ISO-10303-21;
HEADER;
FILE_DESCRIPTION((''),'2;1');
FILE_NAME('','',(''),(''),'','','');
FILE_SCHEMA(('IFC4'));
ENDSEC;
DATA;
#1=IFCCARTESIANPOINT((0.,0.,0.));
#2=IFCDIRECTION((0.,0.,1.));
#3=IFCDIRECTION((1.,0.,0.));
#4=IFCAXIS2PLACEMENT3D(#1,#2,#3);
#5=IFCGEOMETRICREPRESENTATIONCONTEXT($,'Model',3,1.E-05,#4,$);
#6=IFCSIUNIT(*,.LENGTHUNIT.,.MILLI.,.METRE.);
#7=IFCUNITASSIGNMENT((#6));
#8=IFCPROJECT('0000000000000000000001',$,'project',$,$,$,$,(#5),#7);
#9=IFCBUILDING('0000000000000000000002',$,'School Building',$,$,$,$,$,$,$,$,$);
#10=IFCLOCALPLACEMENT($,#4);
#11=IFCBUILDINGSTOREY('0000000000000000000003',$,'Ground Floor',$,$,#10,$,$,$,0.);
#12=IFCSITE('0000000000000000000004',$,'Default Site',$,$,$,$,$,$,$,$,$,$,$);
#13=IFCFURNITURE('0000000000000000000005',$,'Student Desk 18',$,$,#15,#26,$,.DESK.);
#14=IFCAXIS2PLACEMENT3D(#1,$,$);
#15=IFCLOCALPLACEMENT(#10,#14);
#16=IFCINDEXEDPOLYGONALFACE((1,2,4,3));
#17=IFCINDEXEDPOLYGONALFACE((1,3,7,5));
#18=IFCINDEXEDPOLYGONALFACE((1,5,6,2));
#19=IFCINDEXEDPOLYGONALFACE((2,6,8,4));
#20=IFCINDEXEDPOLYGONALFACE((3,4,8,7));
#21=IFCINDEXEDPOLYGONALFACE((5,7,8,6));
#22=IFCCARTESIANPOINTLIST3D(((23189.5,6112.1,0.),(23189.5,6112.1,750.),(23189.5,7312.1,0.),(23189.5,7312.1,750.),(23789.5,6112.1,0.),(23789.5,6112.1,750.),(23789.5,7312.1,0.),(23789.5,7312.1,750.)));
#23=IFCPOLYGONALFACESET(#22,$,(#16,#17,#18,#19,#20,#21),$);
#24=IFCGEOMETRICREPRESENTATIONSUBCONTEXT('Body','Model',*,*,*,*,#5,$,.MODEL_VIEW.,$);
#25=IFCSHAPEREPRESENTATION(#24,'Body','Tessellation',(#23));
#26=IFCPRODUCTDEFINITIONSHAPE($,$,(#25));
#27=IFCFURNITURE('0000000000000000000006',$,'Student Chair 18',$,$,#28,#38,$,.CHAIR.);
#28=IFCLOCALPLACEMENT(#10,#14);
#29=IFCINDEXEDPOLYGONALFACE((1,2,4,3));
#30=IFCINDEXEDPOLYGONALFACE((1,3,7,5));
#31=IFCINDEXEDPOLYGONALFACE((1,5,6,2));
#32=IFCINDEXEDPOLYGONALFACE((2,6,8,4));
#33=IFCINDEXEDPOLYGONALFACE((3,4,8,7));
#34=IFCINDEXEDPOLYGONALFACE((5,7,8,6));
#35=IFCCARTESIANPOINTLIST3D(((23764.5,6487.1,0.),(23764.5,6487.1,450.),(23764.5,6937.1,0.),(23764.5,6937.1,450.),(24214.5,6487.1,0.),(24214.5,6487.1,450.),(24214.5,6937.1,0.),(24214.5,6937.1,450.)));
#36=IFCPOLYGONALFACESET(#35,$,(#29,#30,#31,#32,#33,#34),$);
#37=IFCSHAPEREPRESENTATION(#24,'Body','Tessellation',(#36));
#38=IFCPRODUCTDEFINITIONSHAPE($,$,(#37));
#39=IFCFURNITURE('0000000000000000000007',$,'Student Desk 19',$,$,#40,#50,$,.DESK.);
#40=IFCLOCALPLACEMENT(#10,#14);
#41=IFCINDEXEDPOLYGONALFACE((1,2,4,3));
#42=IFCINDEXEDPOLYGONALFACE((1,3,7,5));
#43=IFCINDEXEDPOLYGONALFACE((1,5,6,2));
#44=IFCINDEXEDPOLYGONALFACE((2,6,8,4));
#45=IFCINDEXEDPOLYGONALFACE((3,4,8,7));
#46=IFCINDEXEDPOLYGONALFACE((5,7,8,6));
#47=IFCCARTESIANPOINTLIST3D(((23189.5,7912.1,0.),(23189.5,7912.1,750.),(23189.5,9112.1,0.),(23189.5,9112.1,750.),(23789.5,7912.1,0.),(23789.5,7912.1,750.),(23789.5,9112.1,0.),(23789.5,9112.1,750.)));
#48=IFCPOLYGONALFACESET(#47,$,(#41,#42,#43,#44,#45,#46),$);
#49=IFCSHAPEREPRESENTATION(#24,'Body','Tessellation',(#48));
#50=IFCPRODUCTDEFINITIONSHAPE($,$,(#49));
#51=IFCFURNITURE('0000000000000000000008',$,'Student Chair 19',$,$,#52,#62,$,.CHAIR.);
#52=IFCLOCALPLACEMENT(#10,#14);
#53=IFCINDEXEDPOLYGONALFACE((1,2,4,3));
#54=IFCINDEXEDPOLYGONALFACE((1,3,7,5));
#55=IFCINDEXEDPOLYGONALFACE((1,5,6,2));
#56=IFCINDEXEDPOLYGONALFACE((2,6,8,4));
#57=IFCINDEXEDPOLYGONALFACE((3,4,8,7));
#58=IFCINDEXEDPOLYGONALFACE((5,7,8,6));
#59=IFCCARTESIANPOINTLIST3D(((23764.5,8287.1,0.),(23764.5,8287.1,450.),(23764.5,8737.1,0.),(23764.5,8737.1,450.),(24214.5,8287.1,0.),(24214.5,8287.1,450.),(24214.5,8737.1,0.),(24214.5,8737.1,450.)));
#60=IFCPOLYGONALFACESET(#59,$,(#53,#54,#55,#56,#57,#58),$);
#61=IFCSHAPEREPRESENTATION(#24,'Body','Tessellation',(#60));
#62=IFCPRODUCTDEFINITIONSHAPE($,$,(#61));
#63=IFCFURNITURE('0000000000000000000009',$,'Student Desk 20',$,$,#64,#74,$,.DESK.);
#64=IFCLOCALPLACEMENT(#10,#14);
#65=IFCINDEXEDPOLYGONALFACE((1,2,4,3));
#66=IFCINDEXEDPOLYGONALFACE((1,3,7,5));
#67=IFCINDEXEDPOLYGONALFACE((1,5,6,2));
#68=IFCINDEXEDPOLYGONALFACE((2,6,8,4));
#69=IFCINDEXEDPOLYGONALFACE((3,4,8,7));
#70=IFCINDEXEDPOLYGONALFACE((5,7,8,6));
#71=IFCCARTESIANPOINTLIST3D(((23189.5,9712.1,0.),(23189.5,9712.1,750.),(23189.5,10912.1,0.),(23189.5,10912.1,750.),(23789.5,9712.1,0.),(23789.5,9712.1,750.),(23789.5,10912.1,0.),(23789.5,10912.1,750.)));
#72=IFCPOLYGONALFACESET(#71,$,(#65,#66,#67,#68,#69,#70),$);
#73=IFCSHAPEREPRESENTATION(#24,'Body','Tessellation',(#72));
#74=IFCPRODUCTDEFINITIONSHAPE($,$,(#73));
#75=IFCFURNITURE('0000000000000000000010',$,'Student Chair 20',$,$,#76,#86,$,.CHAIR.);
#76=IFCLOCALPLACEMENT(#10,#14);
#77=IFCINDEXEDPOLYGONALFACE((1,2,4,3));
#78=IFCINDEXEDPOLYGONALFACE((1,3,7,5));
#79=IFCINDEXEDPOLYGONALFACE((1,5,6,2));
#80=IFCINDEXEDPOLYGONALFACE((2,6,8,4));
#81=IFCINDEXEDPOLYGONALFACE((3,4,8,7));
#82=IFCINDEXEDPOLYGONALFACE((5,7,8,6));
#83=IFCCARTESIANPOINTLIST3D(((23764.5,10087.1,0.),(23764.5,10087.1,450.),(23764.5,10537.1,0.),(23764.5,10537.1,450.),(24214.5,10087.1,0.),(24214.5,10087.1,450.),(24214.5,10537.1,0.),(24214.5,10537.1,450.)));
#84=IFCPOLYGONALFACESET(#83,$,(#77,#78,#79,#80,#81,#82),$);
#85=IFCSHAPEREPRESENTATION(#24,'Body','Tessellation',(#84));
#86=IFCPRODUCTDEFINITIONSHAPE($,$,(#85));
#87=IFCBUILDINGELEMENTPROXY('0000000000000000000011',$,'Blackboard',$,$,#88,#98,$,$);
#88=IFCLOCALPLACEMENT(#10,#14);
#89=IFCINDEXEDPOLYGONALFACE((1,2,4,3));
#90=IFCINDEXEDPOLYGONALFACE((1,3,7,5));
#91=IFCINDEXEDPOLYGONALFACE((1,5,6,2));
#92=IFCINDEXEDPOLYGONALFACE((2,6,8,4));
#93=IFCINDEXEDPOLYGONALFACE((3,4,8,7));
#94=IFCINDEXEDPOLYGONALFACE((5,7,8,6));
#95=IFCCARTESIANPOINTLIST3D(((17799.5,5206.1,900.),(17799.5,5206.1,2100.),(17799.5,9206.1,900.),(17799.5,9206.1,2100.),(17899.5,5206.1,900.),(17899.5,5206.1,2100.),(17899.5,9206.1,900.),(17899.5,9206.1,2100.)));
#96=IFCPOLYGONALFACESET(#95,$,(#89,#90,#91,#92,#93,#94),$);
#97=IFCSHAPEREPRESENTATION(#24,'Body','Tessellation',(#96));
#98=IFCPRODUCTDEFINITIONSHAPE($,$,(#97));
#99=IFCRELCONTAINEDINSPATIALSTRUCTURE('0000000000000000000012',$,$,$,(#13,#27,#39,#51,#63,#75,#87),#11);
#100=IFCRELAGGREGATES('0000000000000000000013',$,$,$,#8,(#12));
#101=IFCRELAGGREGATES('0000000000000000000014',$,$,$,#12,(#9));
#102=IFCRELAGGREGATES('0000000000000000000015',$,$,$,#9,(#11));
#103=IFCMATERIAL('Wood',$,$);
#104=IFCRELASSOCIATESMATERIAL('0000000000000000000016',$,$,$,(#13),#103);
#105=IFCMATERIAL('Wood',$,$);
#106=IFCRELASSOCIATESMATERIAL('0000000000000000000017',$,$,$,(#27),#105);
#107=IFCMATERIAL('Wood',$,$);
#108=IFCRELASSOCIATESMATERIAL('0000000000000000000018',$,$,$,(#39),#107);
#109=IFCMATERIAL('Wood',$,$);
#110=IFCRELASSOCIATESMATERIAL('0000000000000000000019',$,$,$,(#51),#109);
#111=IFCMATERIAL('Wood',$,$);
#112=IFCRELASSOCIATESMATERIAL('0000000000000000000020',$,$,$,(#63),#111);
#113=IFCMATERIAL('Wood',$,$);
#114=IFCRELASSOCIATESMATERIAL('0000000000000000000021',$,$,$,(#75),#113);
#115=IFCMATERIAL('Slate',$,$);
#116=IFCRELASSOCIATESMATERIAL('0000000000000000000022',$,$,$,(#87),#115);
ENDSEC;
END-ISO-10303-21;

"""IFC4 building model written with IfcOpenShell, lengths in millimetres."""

from ifc_helpers import new_model, si_unit, frame, origin_with_axes, origin_2d, place, context, subcontext, project, spatial, rectangle, extrude, material, element, save


model = new_model("IFC4")

# Units and contexts
model_context = context("Model", 3, precision=1e-05, world=origin_with_axes())
body_context = subcontext(model_context, "Body", "Model", "MODEL_VIEW")
ifc_project = project(units=[si_unit("LENGTHUNIT", "METRE", prefix="MILLI")], contexts=[model_context])

# Site, building, storey
site = spatial("IfcSite", under=ifc_project, Name="Default Site")
building = spatial("IfcBuilding", under=site, Name="School Building")
storey_placement = place(None, origin_with_axes())
storey = spatial("IfcBuildingStorey", under=building, at=storey_placement, Name="Ground Floor", Elevation=0.0)

# Furniture
ifc_material_1 = material(Name="Wood")
furniture_1_placement = place(storey_placement, frame((23489.5, 6712.1, 0.0), z_axis=(0.0, 0.0, 1.0), x_axis=(0.0, 1.0, 0.0)))
element("IfcFurniture", 1, at=furniture_1_placement, inside=storey, material=ifc_material_1, Name="Student Desk 18", PredefinedType="DESK", context=body_context, shape_type="SweptSolid", body=[
    extrude(rectangle(XDim=1200.0, YDim=600.0, at=origin_2d()), origin_with_axes(), (0.0, 0.0, 1.0), 750.0),
])
ifc_material_2 = material(Name="Wood")
furniture_2_placement = place(storey_placement, frame((23989.5, 6712.1, 0.0), z_axis=(0.0, 0.0, 1.0), x_axis=(1.0, 0.0, 0.0)))
element("IfcFurniture", 2, at=furniture_2_placement, inside=storey, material=ifc_material_2, Name="Student Chair 18", PredefinedType="CHAIR", context=body_context, shape_type="SweptSolid", body=[
    extrude(rectangle(XDim=450.0, YDim=450.0, at=origin_2d()), origin_with_axes(), (0.0, 0.0, 1.0), 450.0),
])
ifc_material_3 = material(Name="Wood")
furniture_3_placement = place(storey_placement, frame((23489.5, 8512.1, 0.0), z_axis=(0.0, 0.0, 1.0), x_axis=(0.0, 1.0, 0.0)))
element("IfcFurniture", 3, at=furniture_3_placement, inside=storey, material=ifc_material_3, Name="Student Desk 19", PredefinedType="DESK", context=body_context, shape_type="SweptSolid", body=[
    extrude(rectangle(XDim=1200.0, YDim=600.0, at=origin_2d()), origin_with_axes(), (0.0, 0.0, 1.0), 750.0),
])
ifc_material_4 = material(Name="Wood")
furniture_4_placement = place(storey_placement, frame((23989.5, 8512.1, 0.0), z_axis=(0.0, 0.0, 1.0), x_axis=(1.0, 0.0, 0.0)))
element("IfcFurniture", 4, at=furniture_4_placement, inside=storey, material=ifc_material_4, Name="Student Chair 19", PredefinedType="CHAIR", context=body_context, shape_type="SweptSolid", body=[
    extrude(rectangle(XDim=450.0, YDim=450.0, at=origin_2d()), origin_with_axes(), (0.0, 0.0, 1.0), 450.0),
])
ifc_material_5 = material(Name="Wood")
furniture_5_placement = place(storey_placement, frame((23489.5, 10312.1, 0.0), z_axis=(0.0, 0.0, 1.0), x_axis=(0.0, 1.0, 0.0)))
element("IfcFurniture", 5, at=furniture_5_placement, inside=storey, material=ifc_material_5, Name="Student Desk 20", PredefinedType="DESK", context=body_context, shape_type="SweptSolid", body=[
    extrude(rectangle(XDim=1200.0, YDim=600.0, at=origin_2d()), origin_with_axes(), (0.0, 0.0, 1.0), 750.0),
])
ifc_material_6 = material(Name="Wood")
furniture_6_placement = place(storey_placement, frame((23989.5, 10312.1, 0.0), z_axis=(0.0, 0.0, 1.0), x_axis=(1.0, 0.0, 0.0)))
element("IfcFurniture", 6, at=furniture_6_placement, inside=storey, material=ifc_material_6, Name="Student Chair 20", PredefinedType="CHAIR", context=body_context, shape_type="SweptSolid", body=[
    extrude(rectangle(XDim=450.0, YDim=450.0, at=origin_2d()), origin_with_axes(), (0.0, 0.0, 1.0), 450.0),
])

# Building element proxy
ifc_material_7 = material(Name="Slate")
proxy_placement = place(storey_placement, frame((17849.5, 7206.1, 900.0), z_axis=(0.0, 0.0, 1.0), x_axis=(1.0, 0.0, 0.0)))
element("IfcBuildingElementProxy", 7, at=proxy_placement, inside=storey, material=ifc_material_7, Name="Blackboard", context=body_context, shape_type="SweptSolid", body=[
    extrude(rectangle(XDim=100.0, YDim=4000.0, at=origin_2d()), origin_with_axes(), (0.0, 0.0, 1.0), 1200.0),
])

save(model, "model.ifc")
